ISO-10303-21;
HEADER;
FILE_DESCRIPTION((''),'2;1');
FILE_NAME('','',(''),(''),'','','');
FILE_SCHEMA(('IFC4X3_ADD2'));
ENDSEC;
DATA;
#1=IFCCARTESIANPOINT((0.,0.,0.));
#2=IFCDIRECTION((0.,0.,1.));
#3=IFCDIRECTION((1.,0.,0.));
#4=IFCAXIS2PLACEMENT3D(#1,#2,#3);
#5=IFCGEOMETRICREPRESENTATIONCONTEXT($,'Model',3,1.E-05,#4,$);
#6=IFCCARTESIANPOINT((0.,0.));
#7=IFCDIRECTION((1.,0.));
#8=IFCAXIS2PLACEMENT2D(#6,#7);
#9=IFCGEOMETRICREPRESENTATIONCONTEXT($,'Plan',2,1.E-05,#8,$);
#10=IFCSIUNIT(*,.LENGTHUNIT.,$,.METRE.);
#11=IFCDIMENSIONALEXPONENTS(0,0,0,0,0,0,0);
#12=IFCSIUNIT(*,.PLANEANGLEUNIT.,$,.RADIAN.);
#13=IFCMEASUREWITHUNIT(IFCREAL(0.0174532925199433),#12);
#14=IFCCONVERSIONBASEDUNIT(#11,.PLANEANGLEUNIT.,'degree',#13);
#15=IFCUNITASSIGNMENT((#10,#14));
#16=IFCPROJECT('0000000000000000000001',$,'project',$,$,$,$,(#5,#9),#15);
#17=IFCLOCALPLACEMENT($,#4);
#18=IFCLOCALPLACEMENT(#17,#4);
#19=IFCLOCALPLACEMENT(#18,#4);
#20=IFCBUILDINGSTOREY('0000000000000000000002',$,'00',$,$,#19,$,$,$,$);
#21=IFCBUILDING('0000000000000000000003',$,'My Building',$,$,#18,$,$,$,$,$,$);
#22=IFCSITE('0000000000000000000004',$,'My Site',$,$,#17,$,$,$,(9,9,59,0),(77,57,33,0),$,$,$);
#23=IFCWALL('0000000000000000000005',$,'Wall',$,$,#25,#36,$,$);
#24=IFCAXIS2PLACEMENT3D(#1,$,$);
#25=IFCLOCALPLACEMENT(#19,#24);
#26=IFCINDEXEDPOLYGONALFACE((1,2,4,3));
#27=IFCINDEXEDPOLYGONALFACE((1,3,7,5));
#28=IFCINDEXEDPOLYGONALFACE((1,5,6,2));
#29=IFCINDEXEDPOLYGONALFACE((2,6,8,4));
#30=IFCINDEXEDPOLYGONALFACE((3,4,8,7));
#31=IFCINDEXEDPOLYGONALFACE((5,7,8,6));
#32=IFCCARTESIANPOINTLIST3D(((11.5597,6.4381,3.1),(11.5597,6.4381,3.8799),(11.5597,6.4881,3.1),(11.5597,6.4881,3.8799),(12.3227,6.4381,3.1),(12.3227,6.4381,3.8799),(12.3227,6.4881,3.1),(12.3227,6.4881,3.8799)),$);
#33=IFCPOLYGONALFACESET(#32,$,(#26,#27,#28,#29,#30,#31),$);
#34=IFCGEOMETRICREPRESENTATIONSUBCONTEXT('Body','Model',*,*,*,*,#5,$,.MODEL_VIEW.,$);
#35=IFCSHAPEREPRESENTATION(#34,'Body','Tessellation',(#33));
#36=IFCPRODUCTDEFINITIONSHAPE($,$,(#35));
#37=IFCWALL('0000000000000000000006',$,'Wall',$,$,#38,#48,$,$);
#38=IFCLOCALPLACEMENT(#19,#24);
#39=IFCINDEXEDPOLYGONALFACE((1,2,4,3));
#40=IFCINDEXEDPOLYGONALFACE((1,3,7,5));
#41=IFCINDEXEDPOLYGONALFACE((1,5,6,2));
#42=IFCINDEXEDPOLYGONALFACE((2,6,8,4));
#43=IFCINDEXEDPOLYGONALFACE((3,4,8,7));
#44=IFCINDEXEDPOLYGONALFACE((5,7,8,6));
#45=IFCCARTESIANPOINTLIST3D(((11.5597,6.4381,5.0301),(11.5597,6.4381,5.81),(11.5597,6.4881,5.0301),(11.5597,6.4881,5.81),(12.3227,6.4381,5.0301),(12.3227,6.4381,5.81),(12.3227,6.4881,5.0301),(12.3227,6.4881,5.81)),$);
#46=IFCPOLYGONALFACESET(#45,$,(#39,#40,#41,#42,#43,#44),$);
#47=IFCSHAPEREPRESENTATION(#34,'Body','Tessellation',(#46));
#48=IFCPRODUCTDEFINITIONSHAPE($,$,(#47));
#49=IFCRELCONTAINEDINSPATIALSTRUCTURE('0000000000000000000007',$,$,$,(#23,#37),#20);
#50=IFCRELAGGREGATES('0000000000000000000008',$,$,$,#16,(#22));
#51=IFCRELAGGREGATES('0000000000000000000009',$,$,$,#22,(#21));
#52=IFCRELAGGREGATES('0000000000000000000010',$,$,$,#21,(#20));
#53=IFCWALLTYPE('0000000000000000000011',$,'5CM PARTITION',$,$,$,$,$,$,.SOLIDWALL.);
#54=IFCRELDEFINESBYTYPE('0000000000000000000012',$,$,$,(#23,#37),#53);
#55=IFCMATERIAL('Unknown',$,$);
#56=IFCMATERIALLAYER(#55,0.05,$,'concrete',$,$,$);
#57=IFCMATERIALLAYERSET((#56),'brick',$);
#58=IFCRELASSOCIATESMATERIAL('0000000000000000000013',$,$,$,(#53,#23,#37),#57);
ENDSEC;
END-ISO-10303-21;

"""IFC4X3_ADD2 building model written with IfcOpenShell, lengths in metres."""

from ifc_helpers import new_model, entity, si_unit, converted_unit, frame, origin_with_axes, origin_2d_with_axis, place, context, subcontext, project, spatial, line, indexed_curve, outline, extrude, material, layer, layer_set, layer_usage, type_object, element, save


model = new_model("IFC4X3_ADD2")

# Units and contexts
model_context = context("Model", 3, precision=1e-05, world=origin_with_axes())
plan_context = context("Plan", 2, precision=1e-05, world=origin_2d_with_axis())
body_context = subcontext(model_context, "Body", "Model", "MODEL_VIEW")
ifc_project = project(units=[si_unit("LENGTHUNIT", "METRE"), converted_unit("PLANEANGLEUNIT", "degree", entity("IfcReal", 0.0174532925199433), si_unit("PLANEANGLEUNIT", "RADIAN"), dimensions=[0, 0, 0, 0, 0, 0, 0])], contexts=[model_context, plan_context])

# Site, building, storey
site_placement = place(None, origin_with_axes())
site = spatial("IfcSite", under=ifc_project, at=site_placement, Name="My Site", RefLatitude=(9, 9, 59, 0), RefLongitude=(77, 57, 33, 0))
building_placement = place(site_placement, origin_with_axes())
building = spatial("IfcBuilding", under=site, at=building_placement, Name="My Building")
storey_placement = place(building_placement, origin_with_axes())
storey = spatial("IfcBuildingStorey", under=building, at=storey_placement, Name="00")

# Walls
ifc_material_1 = material(Name="Unknown")
ifc_layer = layer(ifc_material_1, 0.05, Name="concrete")
ifc_layer_set = layer_set([ifc_layer], Name="brick")
ifc_layer_usage_1 = layer_usage(ifc_layer_set, "AXIS2", "POSITIVE", 0.0)
wall_type = type_object("IfcWallType", Name="5CM PARTITION", PredefinedType="SOLIDWALL", material=ifc_layer_set)
wall_1_placement = place(storey_placement, frame((11.5597, 6.4381, 3.1), z_axis=(0.0, 0.0, 1.0), x_axis=(1.0, 0.0, 0.0)))
element("IfcWall", 1, at=wall_1_placement, inside=storey, type_object=wall_type, material=ifc_layer_usage_1, Name="Wall", context=body_context, shape_type="SweptSolid", body=[
    extrude(outline(indexed_curve([(0.0, 0.0), (0.0, 0.05), (0.763, 0.05), (0.763, 0.0)], segments=[line(1, 2, 3, 4, 1)])), origin_with_axes(), (0.0, 0.0, 1.0), 0.7799),
])
ifc_layer_usage_2 = layer_usage(ifc_layer_set, "AXIS2", "POSITIVE", 0.0)
wall_2_placement = place(storey_placement, frame((11.5597, 6.4381, 5.0301), z_axis=(0.0, 0.0, 1.0), x_axis=(1.0, 0.0, 0.0)))
element("IfcWall", 2, at=wall_2_placement, inside=storey, type_object=wall_type, material=ifc_layer_usage_2, Name="Wall", context=body_context, shape_type="SweptSolid", body=[
    extrude(outline(indexed_curve([(0.0, 0.0), (0.0, 0.05), (0.763, 0.05), (0.763, 0.0)], segments=[line(1, 2, 3, 4, 1)])), origin_with_axes(), (0.0, 0.0, 1.0), 0.7799),
])

save(model, "model.ifc")
